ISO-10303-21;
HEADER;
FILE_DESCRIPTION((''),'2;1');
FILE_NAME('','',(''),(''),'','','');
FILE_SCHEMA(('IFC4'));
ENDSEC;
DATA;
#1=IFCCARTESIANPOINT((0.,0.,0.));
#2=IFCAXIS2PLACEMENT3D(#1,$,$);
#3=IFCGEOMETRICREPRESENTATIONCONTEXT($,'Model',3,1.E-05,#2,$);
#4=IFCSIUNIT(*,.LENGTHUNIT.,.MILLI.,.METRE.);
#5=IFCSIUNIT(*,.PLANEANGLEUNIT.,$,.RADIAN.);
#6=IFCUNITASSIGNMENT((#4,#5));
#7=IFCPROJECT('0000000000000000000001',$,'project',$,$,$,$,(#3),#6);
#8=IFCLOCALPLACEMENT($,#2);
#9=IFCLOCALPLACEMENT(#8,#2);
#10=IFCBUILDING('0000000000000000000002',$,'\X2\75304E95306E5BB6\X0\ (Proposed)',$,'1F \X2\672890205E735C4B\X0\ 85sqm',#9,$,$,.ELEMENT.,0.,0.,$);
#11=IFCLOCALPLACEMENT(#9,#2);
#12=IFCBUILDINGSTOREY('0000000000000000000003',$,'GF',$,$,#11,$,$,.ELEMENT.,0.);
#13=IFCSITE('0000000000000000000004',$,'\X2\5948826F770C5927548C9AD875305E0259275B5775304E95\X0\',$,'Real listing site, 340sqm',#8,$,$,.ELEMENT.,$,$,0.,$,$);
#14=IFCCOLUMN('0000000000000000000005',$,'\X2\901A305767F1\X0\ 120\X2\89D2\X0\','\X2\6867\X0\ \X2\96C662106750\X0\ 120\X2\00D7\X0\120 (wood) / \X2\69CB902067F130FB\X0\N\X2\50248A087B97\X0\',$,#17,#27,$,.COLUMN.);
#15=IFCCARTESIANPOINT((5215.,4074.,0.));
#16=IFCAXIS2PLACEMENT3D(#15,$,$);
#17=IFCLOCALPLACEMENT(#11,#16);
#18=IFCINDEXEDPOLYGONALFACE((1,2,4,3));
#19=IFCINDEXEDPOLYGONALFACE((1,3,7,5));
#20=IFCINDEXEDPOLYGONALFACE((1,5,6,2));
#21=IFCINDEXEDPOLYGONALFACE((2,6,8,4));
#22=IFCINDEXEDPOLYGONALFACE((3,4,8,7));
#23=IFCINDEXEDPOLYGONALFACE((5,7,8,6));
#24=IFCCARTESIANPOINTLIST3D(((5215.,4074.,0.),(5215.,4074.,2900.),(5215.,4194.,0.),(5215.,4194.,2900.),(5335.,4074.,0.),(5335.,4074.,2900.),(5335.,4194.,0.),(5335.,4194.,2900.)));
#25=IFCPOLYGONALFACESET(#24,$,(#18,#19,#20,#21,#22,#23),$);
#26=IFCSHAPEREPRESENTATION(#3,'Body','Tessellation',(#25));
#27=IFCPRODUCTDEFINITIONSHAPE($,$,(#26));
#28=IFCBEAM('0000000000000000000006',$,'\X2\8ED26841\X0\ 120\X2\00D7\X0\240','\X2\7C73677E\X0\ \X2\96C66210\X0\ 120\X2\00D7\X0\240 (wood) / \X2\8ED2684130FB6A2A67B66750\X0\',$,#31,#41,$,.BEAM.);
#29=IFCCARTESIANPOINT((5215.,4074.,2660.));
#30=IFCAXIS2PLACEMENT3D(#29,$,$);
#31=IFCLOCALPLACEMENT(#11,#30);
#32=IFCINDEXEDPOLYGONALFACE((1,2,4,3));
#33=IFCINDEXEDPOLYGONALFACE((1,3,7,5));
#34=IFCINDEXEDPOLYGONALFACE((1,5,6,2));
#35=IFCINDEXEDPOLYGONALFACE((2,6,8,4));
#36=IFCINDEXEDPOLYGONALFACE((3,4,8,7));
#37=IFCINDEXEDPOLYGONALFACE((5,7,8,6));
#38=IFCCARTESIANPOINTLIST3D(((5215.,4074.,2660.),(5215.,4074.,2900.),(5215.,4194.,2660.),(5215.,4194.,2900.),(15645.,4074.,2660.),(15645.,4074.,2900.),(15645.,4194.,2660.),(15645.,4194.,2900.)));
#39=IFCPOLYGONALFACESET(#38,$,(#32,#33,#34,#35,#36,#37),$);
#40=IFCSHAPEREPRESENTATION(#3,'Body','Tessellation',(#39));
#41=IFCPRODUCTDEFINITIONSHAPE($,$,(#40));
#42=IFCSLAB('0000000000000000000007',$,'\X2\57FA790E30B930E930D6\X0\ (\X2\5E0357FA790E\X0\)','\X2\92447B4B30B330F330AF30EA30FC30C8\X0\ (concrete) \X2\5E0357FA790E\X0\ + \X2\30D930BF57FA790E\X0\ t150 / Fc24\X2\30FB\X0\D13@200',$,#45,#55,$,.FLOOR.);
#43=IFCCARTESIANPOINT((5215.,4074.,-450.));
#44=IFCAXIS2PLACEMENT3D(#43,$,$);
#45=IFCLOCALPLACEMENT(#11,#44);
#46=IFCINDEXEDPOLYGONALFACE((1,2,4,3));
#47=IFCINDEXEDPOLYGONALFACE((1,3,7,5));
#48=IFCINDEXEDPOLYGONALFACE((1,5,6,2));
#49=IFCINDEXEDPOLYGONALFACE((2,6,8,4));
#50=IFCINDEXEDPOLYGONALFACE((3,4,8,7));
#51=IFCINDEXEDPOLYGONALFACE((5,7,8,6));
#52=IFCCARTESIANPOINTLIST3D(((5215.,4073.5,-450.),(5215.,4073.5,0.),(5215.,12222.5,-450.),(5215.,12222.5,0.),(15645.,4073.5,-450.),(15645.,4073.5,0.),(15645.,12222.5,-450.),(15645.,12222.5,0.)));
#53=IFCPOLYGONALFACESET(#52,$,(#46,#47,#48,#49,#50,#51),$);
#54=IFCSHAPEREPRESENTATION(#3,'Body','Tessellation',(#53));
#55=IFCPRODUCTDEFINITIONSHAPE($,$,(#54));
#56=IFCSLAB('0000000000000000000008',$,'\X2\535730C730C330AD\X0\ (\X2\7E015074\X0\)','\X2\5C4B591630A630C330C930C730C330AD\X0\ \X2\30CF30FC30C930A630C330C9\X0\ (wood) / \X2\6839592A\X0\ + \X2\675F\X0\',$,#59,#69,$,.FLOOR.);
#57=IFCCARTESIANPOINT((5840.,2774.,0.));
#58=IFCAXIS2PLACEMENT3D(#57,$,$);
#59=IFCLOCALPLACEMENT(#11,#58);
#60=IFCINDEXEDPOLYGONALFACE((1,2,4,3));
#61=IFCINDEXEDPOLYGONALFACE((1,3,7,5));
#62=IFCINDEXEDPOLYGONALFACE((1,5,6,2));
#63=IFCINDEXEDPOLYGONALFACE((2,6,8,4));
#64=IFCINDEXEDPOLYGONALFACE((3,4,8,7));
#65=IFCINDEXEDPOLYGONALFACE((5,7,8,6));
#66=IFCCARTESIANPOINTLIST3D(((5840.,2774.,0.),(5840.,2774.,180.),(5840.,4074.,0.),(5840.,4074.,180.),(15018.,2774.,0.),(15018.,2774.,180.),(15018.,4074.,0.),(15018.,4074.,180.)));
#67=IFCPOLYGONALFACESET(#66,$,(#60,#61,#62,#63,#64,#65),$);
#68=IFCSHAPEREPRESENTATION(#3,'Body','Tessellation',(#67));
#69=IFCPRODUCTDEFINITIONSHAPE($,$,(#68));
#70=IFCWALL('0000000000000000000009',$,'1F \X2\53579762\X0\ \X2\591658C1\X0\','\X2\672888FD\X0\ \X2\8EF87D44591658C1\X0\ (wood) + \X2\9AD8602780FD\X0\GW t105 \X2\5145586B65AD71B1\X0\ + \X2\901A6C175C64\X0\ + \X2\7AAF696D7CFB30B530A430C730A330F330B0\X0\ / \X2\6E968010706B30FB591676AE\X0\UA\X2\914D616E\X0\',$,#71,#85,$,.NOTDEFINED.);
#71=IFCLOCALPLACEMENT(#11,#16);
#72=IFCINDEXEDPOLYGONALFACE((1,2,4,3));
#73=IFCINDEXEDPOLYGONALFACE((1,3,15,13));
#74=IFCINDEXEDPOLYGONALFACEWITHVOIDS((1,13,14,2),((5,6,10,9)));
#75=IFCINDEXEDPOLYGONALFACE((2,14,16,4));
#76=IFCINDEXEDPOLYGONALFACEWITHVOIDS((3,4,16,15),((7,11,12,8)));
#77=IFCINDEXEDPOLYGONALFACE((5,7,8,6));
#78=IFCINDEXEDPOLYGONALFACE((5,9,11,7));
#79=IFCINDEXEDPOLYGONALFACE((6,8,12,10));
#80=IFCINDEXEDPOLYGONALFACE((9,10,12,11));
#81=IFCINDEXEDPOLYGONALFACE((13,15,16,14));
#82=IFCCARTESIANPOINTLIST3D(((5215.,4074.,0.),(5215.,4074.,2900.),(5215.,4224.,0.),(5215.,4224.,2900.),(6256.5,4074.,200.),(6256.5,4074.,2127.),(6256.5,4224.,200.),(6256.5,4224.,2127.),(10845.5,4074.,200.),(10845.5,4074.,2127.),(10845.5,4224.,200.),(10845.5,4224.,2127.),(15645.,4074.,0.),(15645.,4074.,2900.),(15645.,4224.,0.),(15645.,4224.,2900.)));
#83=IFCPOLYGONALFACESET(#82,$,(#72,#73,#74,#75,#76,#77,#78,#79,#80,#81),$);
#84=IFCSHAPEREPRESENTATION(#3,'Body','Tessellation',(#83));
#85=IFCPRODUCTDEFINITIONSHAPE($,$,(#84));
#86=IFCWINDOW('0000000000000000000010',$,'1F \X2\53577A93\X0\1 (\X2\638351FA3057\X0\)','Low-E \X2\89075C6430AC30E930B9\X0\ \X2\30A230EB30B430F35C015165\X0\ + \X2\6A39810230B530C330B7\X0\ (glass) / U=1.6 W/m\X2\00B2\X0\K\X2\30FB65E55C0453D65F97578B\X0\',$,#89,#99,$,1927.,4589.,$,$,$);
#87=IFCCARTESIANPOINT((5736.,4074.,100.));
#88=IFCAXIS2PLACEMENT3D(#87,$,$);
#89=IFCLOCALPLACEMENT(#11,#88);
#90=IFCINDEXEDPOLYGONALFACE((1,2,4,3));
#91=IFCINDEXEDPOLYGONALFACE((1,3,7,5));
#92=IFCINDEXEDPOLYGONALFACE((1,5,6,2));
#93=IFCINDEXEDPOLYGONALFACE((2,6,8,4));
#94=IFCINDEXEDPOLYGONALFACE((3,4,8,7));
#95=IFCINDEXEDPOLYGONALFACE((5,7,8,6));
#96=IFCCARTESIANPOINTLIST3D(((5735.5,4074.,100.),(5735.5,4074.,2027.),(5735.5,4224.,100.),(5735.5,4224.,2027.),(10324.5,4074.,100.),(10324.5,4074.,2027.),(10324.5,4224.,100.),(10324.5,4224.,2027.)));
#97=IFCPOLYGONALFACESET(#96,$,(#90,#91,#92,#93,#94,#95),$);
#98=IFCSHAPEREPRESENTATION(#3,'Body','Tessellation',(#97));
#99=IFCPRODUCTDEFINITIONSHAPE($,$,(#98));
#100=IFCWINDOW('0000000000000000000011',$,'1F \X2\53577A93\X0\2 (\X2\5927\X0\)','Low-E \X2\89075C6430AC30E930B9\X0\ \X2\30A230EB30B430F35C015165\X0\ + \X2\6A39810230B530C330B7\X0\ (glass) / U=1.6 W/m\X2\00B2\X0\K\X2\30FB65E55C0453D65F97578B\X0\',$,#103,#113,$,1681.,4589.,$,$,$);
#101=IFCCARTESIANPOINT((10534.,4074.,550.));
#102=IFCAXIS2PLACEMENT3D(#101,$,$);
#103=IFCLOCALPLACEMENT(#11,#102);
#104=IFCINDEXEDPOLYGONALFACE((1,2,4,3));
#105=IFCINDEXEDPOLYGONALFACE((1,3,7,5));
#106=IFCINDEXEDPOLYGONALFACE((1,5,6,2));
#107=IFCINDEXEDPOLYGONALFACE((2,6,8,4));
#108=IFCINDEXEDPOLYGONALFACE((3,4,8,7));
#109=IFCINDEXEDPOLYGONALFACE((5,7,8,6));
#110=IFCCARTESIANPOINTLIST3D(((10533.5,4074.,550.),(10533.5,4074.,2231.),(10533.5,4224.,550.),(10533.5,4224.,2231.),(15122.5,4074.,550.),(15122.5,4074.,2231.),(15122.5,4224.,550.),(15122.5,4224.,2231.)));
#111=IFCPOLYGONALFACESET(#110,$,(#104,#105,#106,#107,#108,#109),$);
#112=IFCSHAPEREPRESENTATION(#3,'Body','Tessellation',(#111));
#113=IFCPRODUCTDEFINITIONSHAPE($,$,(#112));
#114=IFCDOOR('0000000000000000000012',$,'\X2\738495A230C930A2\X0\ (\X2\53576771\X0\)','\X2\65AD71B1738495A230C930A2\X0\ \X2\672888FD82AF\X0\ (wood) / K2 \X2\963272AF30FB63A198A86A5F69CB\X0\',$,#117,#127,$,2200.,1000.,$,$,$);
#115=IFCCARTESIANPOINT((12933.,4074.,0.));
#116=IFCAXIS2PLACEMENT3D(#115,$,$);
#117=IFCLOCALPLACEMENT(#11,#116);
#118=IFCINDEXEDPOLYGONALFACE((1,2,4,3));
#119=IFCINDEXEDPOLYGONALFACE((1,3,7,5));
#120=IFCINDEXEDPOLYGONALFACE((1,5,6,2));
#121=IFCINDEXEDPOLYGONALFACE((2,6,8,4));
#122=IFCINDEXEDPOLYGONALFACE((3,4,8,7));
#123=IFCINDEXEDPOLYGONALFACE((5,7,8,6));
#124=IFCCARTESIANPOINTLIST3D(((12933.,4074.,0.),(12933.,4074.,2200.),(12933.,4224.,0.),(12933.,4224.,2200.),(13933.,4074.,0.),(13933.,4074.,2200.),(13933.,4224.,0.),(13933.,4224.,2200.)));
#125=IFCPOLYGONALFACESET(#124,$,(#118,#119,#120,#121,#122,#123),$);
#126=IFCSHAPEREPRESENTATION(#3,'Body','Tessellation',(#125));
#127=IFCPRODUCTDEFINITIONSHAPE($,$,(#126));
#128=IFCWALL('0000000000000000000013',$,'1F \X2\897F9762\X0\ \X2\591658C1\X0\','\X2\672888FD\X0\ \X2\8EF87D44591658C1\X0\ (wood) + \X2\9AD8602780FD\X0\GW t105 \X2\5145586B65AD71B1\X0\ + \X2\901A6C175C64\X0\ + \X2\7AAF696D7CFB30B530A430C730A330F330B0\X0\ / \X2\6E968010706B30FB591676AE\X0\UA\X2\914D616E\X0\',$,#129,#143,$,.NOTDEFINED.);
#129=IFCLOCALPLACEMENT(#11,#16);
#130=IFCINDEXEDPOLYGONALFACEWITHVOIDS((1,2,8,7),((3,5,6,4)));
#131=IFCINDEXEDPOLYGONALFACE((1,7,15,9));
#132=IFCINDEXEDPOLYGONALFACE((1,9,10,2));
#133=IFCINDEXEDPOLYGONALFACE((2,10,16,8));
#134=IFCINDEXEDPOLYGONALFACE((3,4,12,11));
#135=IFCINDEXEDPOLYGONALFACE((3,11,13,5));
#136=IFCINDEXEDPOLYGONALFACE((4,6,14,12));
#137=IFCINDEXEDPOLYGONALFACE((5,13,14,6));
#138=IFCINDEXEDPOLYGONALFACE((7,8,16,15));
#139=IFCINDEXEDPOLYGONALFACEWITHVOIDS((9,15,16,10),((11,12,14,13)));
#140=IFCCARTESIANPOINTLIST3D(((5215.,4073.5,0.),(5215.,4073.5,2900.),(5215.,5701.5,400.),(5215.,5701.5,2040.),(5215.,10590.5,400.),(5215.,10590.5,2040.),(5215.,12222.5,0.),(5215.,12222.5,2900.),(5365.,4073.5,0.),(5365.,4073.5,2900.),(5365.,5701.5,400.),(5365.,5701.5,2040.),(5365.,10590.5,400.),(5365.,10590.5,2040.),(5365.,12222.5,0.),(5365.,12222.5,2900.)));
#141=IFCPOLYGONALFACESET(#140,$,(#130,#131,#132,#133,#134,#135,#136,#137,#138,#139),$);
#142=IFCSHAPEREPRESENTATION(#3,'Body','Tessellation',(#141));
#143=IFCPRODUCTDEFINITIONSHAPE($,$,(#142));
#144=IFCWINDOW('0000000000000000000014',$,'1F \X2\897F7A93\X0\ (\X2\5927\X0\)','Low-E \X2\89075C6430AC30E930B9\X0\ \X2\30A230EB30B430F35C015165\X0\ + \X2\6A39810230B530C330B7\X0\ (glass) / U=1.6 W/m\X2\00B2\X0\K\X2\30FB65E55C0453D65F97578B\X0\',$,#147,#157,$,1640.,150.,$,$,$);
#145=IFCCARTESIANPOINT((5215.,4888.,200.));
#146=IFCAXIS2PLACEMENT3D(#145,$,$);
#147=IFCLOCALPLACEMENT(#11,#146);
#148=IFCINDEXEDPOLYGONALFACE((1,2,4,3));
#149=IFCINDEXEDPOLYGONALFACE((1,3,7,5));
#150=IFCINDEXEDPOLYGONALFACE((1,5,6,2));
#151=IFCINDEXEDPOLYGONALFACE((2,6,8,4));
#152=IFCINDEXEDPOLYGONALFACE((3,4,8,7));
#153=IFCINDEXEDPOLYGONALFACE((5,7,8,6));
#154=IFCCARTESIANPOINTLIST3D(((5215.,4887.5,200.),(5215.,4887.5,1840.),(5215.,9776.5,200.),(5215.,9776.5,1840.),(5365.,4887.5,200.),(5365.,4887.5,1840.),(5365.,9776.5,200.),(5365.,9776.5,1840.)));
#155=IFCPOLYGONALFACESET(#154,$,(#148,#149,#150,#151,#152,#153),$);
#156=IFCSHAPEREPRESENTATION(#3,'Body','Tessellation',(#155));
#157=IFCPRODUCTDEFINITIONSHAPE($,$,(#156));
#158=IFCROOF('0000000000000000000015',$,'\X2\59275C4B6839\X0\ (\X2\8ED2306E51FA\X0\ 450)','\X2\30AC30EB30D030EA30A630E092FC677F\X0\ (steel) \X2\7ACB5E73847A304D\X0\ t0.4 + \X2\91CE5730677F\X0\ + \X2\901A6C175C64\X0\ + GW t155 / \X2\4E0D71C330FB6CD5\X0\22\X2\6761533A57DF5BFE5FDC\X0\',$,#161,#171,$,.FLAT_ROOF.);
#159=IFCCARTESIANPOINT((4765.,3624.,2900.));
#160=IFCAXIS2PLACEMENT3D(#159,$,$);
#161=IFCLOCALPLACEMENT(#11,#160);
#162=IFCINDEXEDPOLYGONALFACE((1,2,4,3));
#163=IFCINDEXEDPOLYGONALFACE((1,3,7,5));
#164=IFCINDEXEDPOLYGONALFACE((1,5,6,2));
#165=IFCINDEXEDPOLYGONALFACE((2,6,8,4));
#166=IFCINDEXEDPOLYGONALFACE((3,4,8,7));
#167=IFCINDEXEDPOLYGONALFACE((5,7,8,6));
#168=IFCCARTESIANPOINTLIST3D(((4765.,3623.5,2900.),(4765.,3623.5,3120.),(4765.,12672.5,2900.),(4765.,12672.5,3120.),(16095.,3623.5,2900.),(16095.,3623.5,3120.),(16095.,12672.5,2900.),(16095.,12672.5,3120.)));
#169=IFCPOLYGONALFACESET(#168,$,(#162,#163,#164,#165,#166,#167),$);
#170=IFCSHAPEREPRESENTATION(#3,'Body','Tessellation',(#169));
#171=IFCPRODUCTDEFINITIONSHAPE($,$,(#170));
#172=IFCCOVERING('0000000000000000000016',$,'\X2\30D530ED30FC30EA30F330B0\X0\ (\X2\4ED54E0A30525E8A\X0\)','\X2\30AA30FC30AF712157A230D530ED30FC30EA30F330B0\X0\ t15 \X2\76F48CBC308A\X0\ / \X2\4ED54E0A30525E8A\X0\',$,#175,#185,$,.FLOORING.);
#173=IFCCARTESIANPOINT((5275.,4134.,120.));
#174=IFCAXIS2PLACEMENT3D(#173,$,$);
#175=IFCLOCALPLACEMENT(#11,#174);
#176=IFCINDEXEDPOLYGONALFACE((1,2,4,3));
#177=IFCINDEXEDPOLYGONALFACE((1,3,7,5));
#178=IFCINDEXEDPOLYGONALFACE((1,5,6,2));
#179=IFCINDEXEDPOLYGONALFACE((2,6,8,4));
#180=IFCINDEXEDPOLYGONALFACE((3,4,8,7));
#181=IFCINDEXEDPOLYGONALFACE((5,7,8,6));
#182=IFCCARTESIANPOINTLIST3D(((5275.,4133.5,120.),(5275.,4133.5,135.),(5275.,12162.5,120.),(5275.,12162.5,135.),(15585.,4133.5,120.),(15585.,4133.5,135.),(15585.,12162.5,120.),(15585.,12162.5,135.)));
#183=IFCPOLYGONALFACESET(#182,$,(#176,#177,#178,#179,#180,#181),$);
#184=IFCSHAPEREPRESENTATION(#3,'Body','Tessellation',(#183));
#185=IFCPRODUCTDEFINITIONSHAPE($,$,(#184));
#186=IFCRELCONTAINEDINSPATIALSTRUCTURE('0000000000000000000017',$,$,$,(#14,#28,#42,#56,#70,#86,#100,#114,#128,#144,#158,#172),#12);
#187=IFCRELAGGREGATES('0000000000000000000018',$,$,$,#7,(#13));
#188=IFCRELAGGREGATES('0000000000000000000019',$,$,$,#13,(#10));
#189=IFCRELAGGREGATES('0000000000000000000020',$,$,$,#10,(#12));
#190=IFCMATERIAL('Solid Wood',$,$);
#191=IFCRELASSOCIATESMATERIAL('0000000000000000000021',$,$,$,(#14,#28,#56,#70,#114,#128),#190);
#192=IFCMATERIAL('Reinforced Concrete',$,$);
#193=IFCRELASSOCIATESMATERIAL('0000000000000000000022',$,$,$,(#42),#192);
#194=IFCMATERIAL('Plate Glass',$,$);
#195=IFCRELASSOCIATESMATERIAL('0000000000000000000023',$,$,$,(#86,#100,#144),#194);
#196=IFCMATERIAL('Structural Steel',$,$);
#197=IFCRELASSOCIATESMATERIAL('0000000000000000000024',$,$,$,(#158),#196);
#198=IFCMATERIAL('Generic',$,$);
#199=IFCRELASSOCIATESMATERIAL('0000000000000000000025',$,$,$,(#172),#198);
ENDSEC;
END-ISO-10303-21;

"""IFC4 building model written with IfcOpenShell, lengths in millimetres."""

from ifc_helpers import new_model, si_unit, frame, frame_2d, origin, place, context, project, spatial, rectangle, extrude, material, element, fill, save


model = new_model("IFC4")

# Units and contexts
model_context = context("Model", 3, precision=1e-05, world=origin())
ifc_project = project(units=[si_unit("LENGTHUNIT", "METRE", prefix="MILLI"), si_unit("PLANEANGLEUNIT", "RADIAN")], contexts=[model_context])

# Site, building, storey
site_placement = place(None, origin())
site = spatial("IfcSite", under=ifc_project, at=site_placement, Name="奈良県大和高田市大字田井", ObjectType="Real listing site, 340sqm", CompositionType="ELEMENT", RefElevation=0.0)
building_placement = place(site_placement, origin())
building = spatial("IfcBuilding", under=site, at=building_placement, Name="田井の家 (Proposed)", ObjectType="1F 木造平屋 85sqm", CompositionType="ELEMENT", ElevationOfRefHeight=0.0, ElevationOfTerrain=0.0)
storey_placement = place(building_placement, origin())
storey = spatial("IfcBuildingStorey", under=building, at=storey_placement, Name="GF", CompositionType="ELEMENT", Elevation=0.0)

# Column
ifc_material_1 = material(Name="Solid Wood")
column_placement = place(storey_placement, frame((5215.0, 4074.0, 0.0)))
element("IfcColumn", 1, at=column_placement, inside=storey, material=ifc_material_1, Name="通し柱 120角", Description="桧 集成材 120×120 (wood) / 構造柱・N値計算", PredefinedType="COLUMN", context=model_context, shape_type="SweptSolid", body=[
    extrude(rectangle(XDim=120.0, YDim=120.0, at=frame_2d((60.0, 60.0))), frame((5215.0, 4074.0, 0.0)), (0.0, 0.0, 1.0), 2900.0),
])

# Beam
beam_1_placement = place(storey_placement, frame((5215.0, 4074.0, 2660.0)))
element("IfcBeam", 2, at=beam_1_placement, inside=storey, material=ifc_material_1, Name="軒桁 120×240", Description="米松 集成 120×240 (wood) / 軒桁・横架材", PredefinedType="BEAM", context=model_context, shape_type="SweptSolid", body=[
    extrude(rectangle(XDim=10430.0, YDim=120.0, at=frame_2d((5215.0, 60.0))), frame((5215.0, 4074.0, 2660.0)), (0.0, 0.0, 1.0), 240.0),
])

# Slabs
ifc_material_2 = material(Name="Reinforced Concrete")
slab_1_placement = place(storey_placement, frame((5215.0, 4074.0, -450.0)))
element("IfcSlab", 3, at=slab_1_placement, inside=storey, material=ifc_material_2, Name="基礎スラブ (布基礎)", Description="鉄筋コンクリート (concrete) 布基礎 + ベタ基礎 t150 / Fc24・D13@200", PredefinedType="FLOOR", context=model_context, shape_type="SweptSolid", body=[
    extrude(rectangle(XDim=10430.0, YDim=8149.0, at=frame_2d((5215.0, 4074.0))), frame((5215.0, 4074.0, -450.0)), (0.0, 0.0, 1.0), 450.0),
])
slab_2_placement = place(storey_placement, frame((5840.0, 2774.0, 0.0)))
element("IfcSlab", 4, at=slab_2_placement, inside=storey, material=ifc_material_1, Name="南デッキ (縁側)", Description="屋外ウッドデッキ ハードウッド (wood) / 根太 + 束", PredefinedType="FLOOR", context=model_context, shape_type="SweptSolid", body=[
    extrude(rectangle(XDim=9178.0, YDim=1300.0, at=frame_2d((4589.0, 650.0))), frame((5840.0, 2774.0, 0.0)), (0.0, 0.0, 1.0), 180.0),
])

# Wall, openings, windows, door
wall_1_placement = place(storey_placement, frame((5215.0, 4074.0, 0.0)))
wall_1 = element("IfcWall", 5, at=wall_1_placement, inside=storey, material=ifc_material_1, Name="1F 南面 外壁", Description="木製 軸組外壁 (wood) + 高性能GW t105 充填断熱 + 通気層 + 窯業系サイディング / 準耐火・外皮UA配慮", PredefinedType="NOTDEFINED", context=model_context, shape_type="SweptSolid", body=[
    extrude(rectangle(XDim=10430.0, YDim=150.0, at=frame_2d((5215.0, 75.0))), frame((5215.0, 4074.0, 0.0)), (0.0, 0.0, 1.0), 2900.0),
])
opening_1_placement = place(storey_placement, frame((5736.0, 4074.0, 100.0)))
opening_1 = element("IfcOpeningElement", 6, at=opening_1_placement, cuts=wall_1, PredefinedType="NOTDEFINED", context=model_context, shape_type="SweptSolid", body=[
    extrude(rectangle(XDim=4589.0, YDim=150.0, at=frame_2d((2294.0, 75.0))), frame((5736.0, 4074.0, 100.0)), (0.0, 0.0, 1.0), 1927.0),
])
opening_2_placement = place(storey_placement, frame((10534.0, 4074.0, 550.0)))
opening_2 = element("IfcOpeningElement", 7, at=opening_2_placement, cuts=wall_1, PredefinedType="NOTDEFINED", context=model_context, shape_type="SweptSolid", body=[
    extrude(rectangle(XDim=4589.0, YDim=150.0, at=frame_2d((2294.0, 75.0))), frame((10534.0, 4074.0, 550.0)), (0.0, 0.0, 1.0), 1681.0),
])
opening_3_placement = place(storey_placement, frame((12933.0, 4074.0, 0.0)))
opening_3 = element("IfcOpeningElement", 8, at=opening_3_placement, cuts=wall_1, PredefinedType="NOTDEFINED", context=model_context, shape_type="SweptSolid", body=[
    extrude(rectangle(XDim=1000.0, YDim=150.0, at=frame_2d((500.0, 75.0))), frame((12933.0, 4074.0, 0.0)), (0.0, 0.0, 1.0), 2200.0),
])
ifc_material_3 = material(Name="Plate Glass")
window_1_placement = place(storey_placement, frame((5736.0, 4074.0, 100.0)))
window_1 = element("IfcWindow", 9, at=window_1_placement, inside=storey, material=ifc_material_3, Name="1F 南窓1 (掃出し)", Description="Low-E 複層ガラス アルゴン封入 + 樹脂サッシ (glass) / U=1.6 W/m²K・日射取得型", OverallHeight=1927.0, OverallWidth=4589.0, context=model_context, shape_type="SweptSolid", body=[
    extrude(rectangle(XDim=4589.0, YDim=150.0, at=frame_2d((2294.0, 75.0))), frame((5736.0, 4074.0, 100.0)), (0.0, 0.0, 1.0), 1927.0),
])
fill(opening_1, window_1)
window_2_placement = place(storey_placement, frame((10534.0, 4074.0, 550.0)))
window_2 = element("IfcWindow", 10, at=window_2_placement, inside=storey, material=ifc_material_3, Name="1F 南窓2 (大)", Description="Low-E 複層ガラス アルゴン封入 + 樹脂サッシ (glass) / U=1.6 W/m²K・日射取得型", OverallHeight=1681.0, OverallWidth=4589.0, context=model_context, shape_type="SweptSolid", body=[
    extrude(rectangle(XDim=4589.0, YDim=150.0, at=frame_2d((2294.0, 75.0))), frame((10534.0, 4074.0, 550.0)), (0.0, 0.0, 1.0), 1681.0),
])
fill(opening_2, window_2)
door_placement = place(storey_placement, frame((12933.0, 4074.0, 0.0)))
door = element("IfcDoor", 11, at=door_placement, inside=storey, material=ifc_material_1, Name="玄関ドア (南東)", Description="断熱玄関ドア 木製芯 (wood) / K2 防犯・採風機構", OverallHeight=2200.0, OverallWidth=1000.0, context=model_context, shape_type="SweptSolid", body=[
    extrude(rectangle(XDim=1000.0, YDim=150.0, at=frame_2d((500.0, 75.0))), frame((12933.0, 4074.0, 0.0)), (0.0, 0.0, 1.0), 2200.0),
])
fill(opening_3, door)

# Wall, opening, window
wall_2_placement = place(storey_placement, frame((5215.0, 4074.0, 0.0)))
wall_2 = element("IfcWall", 12, at=wall_2_placement, inside=storey, material=ifc_material_1, Name="1F 西面 外壁", Description="木製 軸組外壁 (wood) + 高性能GW t105 充填断熱 + 通気層 + 窯業系サイディング / 準耐火・外皮UA配慮", PredefinedType="NOTDEFINED", context=model_context, shape_type="SweptSolid", body=[
    extrude(rectangle(XDim=150.0, YDim=8149.0, at=frame_2d((75.0, 4074.0))), frame((5215.0, 4074.0, 0.0)), (0.0, 0.0, 1.0), 2900.0),
])
opening_4_placement = place(storey_placement, frame((5215.0, 4888.0, 200.0)))
opening_4 = element("IfcOpeningElement", 13, at=opening_4_placement, cuts=wall_2, PredefinedType="NOTDEFINED", context=model_context, shape_type="SweptSolid", body=[
    extrude(rectangle(XDim=150.0, YDim=4889.0, at=frame_2d((75.0, 2444.0))), frame((5215.0, 4888.0, 200.0)), (0.0, 0.0, 1.0), 1640.0),
])
window_3_placement = place(storey_placement, frame((5215.0, 4888.0, 200.0)))
window_3 = element("IfcWindow", 14, at=window_3_placement, inside=storey, material=ifc_material_3, Name="1F 西窓 (大)", Description="Low-E 複層ガラス アルゴン封入 + 樹脂サッシ (glass) / U=1.6 W/m²K・日射取得型", OverallHeight=1640.0, OverallWidth=150.0, context=model_context, shape_type="SweptSolid", body=[
    extrude(rectangle(XDim=150.0, YDim=4889.0, at=frame_2d((75.0, 2444.0))), frame((5215.0, 4888.0, 200.0)), (0.0, 0.0, 1.0), 1640.0),
])
fill(opening_4, window_3)

# Roof
ifc_material_4 = material(Name="Structural Steel")
roof_placement = place(storey_placement, frame((4765.0, 3624.0, 2900.0)))
element("IfcRoof", 15, at=roof_placement, inside=storey, material=ifc_material_4, Name="大屋根 (軒の出 450)", Description="ガルバリウム鋼板 (steel) 立平葺き t0.4 + 野地板 + 通気層 + GW t155 / 不燃・法22条区域対応", PredefinedType="FLAT_ROOF", context=model_context, shape_type="SweptSolid", body=[
    extrude(rectangle(XDim=11330.0, YDim=9049.0, at=frame_2d((5665.0, 4524.0))), frame((4765.0, 3624.0, 2900.0)), (0.0, 0.0, 1.0), 220.0),
])

# Covering
ifc_material_5 = material(Name="Generic")
covering_1_placement = place(storey_placement, frame((5275.0, 4134.0, 120.0)))
element("IfcCovering", 16, at=covering_1_placement, inside=storey, material=ifc_material_5, Name="フローリング (仕上げ床)", Description="オーク無垢フローリング t15 直貼り / 仕上げ床", PredefinedType="FLOORING", context=model_context, shape_type="SweptSolid", body=[
    extrude(rectangle(XDim=10310.0, YDim=8029.0, at=frame_2d((5155.0, 4014.0))), frame((5275.0, 4134.0, 120.0)), (0.0, 0.0, 1.0), 15.0),
])

save(model, "model.ifc")
